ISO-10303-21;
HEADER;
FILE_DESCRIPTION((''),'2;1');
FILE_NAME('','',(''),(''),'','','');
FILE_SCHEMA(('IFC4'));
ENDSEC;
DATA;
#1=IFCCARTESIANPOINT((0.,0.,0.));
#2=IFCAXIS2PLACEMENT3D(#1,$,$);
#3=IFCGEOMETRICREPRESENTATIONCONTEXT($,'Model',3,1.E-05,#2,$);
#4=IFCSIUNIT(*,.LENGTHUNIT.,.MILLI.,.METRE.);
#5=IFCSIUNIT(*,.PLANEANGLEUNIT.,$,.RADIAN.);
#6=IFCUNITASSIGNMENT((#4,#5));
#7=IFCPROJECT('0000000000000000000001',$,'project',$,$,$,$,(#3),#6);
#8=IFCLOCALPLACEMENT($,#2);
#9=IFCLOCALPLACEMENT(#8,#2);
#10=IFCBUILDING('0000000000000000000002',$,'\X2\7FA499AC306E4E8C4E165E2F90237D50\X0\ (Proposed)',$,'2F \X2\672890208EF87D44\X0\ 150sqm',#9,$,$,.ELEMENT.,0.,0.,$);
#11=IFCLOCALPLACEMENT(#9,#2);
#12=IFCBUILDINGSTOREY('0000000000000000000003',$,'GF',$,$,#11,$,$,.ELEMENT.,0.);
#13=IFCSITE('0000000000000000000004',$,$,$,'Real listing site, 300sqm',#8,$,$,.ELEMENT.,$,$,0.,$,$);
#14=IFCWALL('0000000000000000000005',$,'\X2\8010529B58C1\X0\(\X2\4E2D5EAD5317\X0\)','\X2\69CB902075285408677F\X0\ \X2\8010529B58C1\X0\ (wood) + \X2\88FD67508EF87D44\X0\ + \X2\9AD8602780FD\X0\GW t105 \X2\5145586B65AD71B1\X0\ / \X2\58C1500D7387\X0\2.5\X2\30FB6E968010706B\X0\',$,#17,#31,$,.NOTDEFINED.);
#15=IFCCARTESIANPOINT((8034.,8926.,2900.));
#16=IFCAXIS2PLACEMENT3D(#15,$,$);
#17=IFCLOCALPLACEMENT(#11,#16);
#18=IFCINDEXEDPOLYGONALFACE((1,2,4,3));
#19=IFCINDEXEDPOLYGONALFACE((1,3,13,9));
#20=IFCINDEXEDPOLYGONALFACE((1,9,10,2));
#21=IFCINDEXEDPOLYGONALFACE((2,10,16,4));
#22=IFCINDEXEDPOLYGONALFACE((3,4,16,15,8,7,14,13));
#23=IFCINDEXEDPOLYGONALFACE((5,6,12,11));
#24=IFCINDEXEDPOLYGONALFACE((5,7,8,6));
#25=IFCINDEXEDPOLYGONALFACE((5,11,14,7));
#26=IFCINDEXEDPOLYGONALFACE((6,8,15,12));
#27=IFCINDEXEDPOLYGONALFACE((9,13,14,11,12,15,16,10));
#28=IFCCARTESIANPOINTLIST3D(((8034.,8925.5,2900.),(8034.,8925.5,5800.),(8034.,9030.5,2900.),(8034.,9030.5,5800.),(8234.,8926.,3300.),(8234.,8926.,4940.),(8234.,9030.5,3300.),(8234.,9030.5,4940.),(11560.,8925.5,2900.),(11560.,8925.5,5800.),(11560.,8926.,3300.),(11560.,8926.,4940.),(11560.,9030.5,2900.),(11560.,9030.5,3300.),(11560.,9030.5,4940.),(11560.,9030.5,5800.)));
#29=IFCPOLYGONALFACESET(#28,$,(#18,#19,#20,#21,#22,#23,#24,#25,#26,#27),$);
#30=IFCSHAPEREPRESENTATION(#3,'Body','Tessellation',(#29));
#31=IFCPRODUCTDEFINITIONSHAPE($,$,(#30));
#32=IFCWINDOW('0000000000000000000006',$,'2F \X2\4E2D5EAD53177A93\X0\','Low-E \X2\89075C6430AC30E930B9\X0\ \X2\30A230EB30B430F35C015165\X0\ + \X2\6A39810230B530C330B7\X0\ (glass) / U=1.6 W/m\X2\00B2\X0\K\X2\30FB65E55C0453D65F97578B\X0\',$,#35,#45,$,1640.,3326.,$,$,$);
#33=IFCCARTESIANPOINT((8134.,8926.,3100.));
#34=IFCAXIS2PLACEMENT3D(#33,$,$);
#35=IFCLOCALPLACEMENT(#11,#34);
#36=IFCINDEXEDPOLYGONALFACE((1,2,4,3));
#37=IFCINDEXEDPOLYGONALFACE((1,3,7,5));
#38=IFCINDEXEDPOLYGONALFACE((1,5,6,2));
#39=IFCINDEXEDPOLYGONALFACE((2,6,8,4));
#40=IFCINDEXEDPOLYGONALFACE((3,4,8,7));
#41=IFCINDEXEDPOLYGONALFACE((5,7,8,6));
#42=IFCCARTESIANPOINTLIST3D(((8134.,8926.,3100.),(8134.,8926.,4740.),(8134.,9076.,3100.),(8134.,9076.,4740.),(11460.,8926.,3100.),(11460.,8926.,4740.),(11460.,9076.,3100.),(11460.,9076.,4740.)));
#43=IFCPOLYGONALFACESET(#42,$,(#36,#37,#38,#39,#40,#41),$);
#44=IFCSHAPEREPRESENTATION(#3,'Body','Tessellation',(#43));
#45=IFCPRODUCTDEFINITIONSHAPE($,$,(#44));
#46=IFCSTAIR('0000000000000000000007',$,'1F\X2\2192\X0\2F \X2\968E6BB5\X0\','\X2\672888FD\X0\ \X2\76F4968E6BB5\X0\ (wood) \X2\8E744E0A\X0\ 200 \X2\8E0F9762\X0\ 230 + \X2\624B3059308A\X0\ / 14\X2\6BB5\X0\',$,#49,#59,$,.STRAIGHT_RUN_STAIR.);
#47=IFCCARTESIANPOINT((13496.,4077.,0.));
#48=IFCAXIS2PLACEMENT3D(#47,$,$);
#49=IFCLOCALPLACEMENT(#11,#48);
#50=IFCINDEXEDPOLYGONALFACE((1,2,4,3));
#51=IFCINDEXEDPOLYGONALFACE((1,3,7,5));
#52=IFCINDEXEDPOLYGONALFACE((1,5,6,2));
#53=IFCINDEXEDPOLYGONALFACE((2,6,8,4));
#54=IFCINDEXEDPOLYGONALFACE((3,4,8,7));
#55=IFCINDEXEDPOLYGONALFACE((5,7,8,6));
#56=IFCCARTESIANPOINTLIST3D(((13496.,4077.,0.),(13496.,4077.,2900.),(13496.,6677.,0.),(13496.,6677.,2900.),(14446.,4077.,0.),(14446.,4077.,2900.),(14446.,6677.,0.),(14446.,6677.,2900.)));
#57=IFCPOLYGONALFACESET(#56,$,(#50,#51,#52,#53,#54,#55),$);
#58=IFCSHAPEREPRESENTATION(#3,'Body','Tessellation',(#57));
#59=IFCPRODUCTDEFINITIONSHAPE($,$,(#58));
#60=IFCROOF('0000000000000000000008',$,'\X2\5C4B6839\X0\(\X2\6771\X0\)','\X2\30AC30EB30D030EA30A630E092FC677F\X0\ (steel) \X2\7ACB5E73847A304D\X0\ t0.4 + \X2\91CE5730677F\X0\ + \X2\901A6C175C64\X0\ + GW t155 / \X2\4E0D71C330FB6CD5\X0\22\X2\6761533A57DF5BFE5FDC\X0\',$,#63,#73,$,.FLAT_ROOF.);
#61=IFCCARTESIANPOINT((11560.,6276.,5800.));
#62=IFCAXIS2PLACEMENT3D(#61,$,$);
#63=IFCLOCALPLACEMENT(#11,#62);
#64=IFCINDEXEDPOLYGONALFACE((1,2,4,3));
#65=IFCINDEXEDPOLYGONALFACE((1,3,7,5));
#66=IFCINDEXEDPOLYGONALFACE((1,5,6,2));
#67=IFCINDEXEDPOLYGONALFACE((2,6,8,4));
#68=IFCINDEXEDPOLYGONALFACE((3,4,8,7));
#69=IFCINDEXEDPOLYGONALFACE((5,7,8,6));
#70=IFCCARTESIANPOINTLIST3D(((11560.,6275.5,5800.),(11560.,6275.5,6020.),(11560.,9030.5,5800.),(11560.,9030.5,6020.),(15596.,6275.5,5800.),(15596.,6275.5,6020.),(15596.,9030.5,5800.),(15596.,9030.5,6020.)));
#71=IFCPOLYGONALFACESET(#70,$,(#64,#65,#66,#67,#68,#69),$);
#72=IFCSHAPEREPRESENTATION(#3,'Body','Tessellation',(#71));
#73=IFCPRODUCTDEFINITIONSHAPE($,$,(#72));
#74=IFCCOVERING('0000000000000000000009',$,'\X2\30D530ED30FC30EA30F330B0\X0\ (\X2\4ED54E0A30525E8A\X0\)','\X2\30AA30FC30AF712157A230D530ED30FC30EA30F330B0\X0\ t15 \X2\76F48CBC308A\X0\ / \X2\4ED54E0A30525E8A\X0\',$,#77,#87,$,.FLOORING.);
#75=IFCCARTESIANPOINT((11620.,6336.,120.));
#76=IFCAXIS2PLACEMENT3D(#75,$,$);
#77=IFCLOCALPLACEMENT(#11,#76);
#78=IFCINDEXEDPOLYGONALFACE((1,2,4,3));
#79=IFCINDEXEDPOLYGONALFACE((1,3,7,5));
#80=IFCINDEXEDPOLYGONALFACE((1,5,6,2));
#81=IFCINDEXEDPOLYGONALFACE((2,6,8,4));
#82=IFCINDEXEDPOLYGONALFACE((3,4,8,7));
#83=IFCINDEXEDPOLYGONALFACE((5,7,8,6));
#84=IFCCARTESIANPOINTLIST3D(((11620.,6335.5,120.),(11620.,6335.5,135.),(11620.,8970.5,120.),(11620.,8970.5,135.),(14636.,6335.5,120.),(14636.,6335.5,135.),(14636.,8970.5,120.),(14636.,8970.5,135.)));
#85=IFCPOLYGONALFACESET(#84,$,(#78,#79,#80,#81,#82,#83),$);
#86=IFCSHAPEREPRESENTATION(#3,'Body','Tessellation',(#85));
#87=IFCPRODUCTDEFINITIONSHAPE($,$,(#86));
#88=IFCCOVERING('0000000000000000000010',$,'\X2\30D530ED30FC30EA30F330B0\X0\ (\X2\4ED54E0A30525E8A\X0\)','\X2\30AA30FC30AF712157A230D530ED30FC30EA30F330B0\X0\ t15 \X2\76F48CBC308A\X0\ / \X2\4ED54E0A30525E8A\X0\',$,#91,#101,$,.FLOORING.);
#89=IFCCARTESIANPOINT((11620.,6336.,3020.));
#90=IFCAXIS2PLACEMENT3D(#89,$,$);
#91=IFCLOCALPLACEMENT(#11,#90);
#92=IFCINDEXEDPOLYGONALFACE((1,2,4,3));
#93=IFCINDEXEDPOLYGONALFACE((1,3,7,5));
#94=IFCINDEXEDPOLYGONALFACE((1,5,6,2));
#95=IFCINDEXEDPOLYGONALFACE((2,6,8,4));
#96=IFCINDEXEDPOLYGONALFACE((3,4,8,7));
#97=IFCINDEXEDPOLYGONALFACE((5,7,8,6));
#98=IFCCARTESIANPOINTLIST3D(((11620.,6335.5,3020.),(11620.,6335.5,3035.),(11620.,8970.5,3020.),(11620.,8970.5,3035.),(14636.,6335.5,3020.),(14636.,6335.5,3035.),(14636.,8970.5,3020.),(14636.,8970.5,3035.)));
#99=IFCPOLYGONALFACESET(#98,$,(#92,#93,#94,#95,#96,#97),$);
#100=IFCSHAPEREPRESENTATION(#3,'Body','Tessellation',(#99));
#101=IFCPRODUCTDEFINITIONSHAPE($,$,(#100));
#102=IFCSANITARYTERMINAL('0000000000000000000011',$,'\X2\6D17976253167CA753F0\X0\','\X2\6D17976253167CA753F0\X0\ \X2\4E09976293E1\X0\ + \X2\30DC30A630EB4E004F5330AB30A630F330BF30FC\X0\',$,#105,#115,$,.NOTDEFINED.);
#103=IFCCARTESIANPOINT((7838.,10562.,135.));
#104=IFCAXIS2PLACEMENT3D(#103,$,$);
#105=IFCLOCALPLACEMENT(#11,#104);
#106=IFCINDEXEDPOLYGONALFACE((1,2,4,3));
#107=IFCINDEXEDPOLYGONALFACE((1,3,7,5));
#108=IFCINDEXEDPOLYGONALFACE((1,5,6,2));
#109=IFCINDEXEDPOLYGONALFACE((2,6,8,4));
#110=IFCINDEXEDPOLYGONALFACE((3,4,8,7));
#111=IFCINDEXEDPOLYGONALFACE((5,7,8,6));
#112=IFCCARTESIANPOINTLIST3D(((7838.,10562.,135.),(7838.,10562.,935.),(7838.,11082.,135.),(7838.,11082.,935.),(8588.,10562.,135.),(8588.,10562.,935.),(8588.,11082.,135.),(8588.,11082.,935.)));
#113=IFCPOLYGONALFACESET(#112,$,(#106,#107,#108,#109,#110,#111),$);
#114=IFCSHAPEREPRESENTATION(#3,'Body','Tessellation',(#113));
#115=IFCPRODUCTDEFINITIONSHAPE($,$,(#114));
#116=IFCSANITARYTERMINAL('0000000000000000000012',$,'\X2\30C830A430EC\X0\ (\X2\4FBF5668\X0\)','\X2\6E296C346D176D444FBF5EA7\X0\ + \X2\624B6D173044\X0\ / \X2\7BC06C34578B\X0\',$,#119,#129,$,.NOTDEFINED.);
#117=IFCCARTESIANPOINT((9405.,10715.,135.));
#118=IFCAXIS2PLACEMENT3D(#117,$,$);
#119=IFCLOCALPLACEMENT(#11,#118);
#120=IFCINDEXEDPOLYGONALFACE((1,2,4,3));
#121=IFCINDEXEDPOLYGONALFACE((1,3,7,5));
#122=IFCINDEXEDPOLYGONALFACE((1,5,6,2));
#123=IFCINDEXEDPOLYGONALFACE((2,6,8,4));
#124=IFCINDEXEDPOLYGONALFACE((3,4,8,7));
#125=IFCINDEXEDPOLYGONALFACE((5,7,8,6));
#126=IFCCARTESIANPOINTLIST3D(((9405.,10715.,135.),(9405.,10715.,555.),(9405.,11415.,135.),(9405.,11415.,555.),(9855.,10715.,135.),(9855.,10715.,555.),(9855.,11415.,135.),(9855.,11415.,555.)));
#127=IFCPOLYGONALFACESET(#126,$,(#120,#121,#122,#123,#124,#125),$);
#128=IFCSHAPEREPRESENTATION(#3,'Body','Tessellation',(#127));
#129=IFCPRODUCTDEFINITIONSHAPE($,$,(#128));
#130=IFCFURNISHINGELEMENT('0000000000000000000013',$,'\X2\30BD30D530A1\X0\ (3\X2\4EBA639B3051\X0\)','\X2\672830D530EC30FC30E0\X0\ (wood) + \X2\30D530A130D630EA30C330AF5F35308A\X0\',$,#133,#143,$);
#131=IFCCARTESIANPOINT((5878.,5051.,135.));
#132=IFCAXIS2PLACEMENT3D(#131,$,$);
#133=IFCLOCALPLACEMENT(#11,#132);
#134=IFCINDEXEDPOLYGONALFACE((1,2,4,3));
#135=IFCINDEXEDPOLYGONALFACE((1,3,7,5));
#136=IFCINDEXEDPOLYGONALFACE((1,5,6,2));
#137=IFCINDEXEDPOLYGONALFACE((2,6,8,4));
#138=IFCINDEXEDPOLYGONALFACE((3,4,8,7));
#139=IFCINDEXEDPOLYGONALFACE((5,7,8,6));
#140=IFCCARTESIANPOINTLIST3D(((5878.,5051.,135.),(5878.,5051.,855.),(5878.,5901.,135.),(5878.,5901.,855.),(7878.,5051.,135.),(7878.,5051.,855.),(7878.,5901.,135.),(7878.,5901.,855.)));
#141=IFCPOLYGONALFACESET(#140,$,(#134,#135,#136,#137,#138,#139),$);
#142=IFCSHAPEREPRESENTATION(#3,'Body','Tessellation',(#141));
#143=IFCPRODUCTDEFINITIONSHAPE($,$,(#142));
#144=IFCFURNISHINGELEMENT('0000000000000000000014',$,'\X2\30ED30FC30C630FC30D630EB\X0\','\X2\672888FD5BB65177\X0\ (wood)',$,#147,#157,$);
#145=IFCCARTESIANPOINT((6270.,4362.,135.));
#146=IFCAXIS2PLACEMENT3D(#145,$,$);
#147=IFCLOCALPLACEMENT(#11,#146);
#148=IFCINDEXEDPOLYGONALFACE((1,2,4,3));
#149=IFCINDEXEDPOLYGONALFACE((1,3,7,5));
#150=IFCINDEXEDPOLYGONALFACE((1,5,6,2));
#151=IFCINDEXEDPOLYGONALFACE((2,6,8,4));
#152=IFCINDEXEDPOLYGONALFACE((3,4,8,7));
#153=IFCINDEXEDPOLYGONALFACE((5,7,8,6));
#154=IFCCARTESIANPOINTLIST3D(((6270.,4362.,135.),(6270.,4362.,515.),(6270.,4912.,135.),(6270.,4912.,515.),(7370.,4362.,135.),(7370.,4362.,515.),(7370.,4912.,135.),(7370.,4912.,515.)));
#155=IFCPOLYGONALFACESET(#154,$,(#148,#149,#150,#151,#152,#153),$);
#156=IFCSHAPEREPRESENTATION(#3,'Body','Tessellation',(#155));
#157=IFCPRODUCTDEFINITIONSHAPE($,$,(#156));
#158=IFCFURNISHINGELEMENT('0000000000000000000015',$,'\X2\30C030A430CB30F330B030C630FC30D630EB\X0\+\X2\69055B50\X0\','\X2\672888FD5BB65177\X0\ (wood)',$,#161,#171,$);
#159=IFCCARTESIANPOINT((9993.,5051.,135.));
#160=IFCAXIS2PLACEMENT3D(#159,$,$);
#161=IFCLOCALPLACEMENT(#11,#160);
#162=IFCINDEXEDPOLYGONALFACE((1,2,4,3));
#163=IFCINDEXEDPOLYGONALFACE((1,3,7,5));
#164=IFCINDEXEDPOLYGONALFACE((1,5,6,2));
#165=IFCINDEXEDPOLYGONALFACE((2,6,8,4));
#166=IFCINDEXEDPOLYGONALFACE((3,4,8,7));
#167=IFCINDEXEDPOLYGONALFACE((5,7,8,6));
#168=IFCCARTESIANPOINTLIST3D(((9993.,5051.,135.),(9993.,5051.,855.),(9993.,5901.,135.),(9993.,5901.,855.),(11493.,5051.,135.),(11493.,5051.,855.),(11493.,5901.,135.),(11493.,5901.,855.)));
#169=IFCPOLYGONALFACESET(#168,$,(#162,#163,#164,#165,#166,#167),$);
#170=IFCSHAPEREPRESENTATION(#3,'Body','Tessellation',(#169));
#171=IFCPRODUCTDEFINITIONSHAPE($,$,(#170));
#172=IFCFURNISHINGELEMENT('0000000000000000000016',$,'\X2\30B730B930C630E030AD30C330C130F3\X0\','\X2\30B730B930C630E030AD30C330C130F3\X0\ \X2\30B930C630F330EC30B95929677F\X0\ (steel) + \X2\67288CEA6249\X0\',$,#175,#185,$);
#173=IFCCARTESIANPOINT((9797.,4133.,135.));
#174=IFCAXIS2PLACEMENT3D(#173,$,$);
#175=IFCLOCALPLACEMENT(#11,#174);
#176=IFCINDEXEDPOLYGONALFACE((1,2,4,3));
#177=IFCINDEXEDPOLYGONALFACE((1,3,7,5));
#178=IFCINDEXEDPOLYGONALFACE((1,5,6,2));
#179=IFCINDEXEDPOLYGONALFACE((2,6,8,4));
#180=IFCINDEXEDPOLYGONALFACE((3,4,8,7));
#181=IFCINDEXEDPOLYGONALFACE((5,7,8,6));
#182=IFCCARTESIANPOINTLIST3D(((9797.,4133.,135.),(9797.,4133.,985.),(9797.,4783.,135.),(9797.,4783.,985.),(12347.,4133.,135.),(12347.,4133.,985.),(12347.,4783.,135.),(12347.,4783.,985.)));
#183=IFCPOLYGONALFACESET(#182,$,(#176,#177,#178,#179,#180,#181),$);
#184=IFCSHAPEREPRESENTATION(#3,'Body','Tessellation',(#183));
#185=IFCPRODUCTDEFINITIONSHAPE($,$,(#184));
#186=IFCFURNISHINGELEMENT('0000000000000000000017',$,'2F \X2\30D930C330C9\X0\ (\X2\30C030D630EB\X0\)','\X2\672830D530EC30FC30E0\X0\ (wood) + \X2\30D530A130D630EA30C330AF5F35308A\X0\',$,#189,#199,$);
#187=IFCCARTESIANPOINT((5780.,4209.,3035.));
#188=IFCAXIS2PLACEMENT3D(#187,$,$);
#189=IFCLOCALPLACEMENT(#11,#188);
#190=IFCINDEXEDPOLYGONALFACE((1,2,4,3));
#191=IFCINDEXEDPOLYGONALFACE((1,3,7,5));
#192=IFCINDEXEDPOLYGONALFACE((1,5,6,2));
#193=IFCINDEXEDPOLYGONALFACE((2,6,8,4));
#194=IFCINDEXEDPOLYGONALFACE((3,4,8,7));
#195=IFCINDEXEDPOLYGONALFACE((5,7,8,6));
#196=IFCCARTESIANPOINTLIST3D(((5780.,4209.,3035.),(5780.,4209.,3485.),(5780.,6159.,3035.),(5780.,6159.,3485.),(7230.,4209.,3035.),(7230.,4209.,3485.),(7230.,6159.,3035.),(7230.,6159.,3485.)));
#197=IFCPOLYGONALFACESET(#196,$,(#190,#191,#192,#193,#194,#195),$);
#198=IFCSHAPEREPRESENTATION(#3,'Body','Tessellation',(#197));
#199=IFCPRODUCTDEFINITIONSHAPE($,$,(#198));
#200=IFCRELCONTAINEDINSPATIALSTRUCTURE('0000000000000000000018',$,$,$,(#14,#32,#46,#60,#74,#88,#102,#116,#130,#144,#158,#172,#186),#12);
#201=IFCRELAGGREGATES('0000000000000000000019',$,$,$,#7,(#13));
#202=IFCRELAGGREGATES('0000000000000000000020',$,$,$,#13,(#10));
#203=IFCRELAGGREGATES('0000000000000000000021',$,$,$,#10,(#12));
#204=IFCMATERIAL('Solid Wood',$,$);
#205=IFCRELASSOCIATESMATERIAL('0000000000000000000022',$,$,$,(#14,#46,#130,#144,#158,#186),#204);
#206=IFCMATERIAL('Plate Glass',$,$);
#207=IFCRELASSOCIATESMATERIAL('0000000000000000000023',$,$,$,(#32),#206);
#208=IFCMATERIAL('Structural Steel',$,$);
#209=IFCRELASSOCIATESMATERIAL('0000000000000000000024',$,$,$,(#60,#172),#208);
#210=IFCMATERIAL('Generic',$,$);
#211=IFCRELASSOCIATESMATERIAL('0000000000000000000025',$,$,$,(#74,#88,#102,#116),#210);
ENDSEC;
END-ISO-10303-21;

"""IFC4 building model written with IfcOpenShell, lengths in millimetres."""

from ifc_helpers import new_model, si_unit, frame, frame_2d, origin, place, context, project, spatial, rectangle, extrude, material, element, fill, save


model = new_model("IFC4")

# Units and contexts
model_context = context("Model", 3, precision=1e-05, world=origin())
ifc_project = project(units=[si_unit("LENGTHUNIT", "METRE", prefix="MILLI"), si_unit("PLANEANGLEUNIT", "RADIAN")], contexts=[model_context])

# Site, building, storey
site_placement = place(None, origin())
site = spatial("IfcSite", under=ifc_project, at=site_placement, ObjectType="Real listing site, 300sqm", CompositionType="ELEMENT", RefElevation=0.0)
building_placement = place(site_placement, origin())
building = spatial("IfcBuilding", under=site, at=building_placement, Name="群馬の二世帯連結 (Proposed)", ObjectType="2F 木造軸組 150sqm", CompositionType="ELEMENT", ElevationOfRefHeight=0.0, ElevationOfTerrain=0.0)
storey_placement = place(building_placement, origin())
storey = spatial("IfcBuildingStorey", under=building, at=storey_placement, Name="GF", CompositionType="ELEMENT", Elevation=0.0)

# Shared definitions
ifc_material_1 = material(Name="Solid Wood")

# Shared definitions
ifc_material_2 = material(Name="Plate Glass")

# Wall, opening, window
wall_1_placement = place(storey_placement, frame((8034.0, 8926.0, 2900.0)))
wall_1 = element("IfcWall", 1, at=wall_1_placement, inside=storey, material=ifc_material_1, Name="耐力壁(中庭北)", Description="構造用合板 耐力壁 (wood) + 製材軸組 + 高性能GW t105 充填断熱 / 壁倍率2.5・準耐火", PredefinedType="NOTDEFINED", context=model_context, shape_type="SweptSolid", body=[
    extrude(rectangle(XDim=3526.0, YDim=105.0, at=frame_2d((1763.0, 52.0))), frame((8034.0, 8926.0, 2900.0)), (0.0, 0.0, 1.0), 2900.0),
])
opening_1_placement = place(storey_placement, frame((8134.0, 8926.0, 3100.0)))
opening_1 = element("IfcOpeningElement", 2, at=opening_1_placement, cuts=wall_1, PredefinedType="NOTDEFINED", context=model_context, shape_type="SweptSolid", body=[
    extrude(rectangle(XDim=3326.0, YDim=150.0, at=frame_2d((1663.0, 75.0))), frame((8134.0, 8926.0, 3100.0)), (0.0, 0.0, 1.0), 1640.0),
])
window_1_placement = place(storey_placement, frame((8134.0, 8926.0, 3100.0)))
window_1 = element("IfcWindow", 3, at=window_1_placement, inside=storey, material=ifc_material_2, Name="2F 中庭北窓", Description="Low-E 複層ガラス アルゴン封入 + 樹脂サッシ (glass) / U=1.6 W/m²K・日射取得型", OverallHeight=1640.0, OverallWidth=3326.0, context=model_context, shape_type="SweptSolid", body=[
    extrude(rectangle(XDim=3326.0, YDim=150.0, at=frame_2d((1663.0, 75.0))), frame((8134.0, 8926.0, 3100.0)), (0.0, 0.0, 1.0), 1640.0),
])
fill(opening_1, window_1)

# Stair
stair_placement = place(storey_placement, frame((13496.0, 4077.0, 0.0)))
element("IfcStair", 4, at=stair_placement, inside=storey, material=ifc_material_1, Name="1F→2F 階段", Description="木製 直階段 (wood) 蹴上 200 踏面 230 + 手すり / 14段", PredefinedType="STRAIGHT_RUN_STAIR", context=model_context, shape_type="SweptSolid", body=[
    extrude(rectangle(XDim=950.0, YDim=2600.0, at=frame_2d((475.0, 1300.0))), frame((13496.0, 4077.0, 0.0)), (0.0, 0.0, 1.0), 2900.0),
])

# Roof
ifc_material_3 = material(Name="Structural Steel")
for number, where, name in (
    (5, (11560.0, 6276.0, 5800.0), "屋根(東)"),
):
    element("IfcRoof", number, at=place(storey_placement, frame(where)), inside=storey, material=ifc_material_3, Name=name, Description="ガルバリウム鋼板 (steel) 立平葺き t0.4 + 野地板 + 通気層 + GW t155 / 不燃・法22条区域対応", PredefinedType="FLAT_ROOF", context=model_context, shape_type="SweptSolid", body=[
        extrude(rectangle(XDim=4036.0, YDim=2755.0, at=frame_2d((2018.0, 1377.0))), frame((11560.0, 6276.0, 5800.0)), (0.0, 0.0, 1.0), 220.0),
    ])

# Coverings
ifc_material_4 = material(Name="Generic")
covering_1_placement = place(storey_placement, frame((11620.0, 6336.0, 120.0)))
element("IfcCovering", 6, at=covering_1_placement, inside=storey, material=ifc_material_4, Name="フローリング (仕上げ床)", Description="オーク無垢フローリング t15 直貼り / 仕上げ床", PredefinedType="FLOORING", context=model_context, shape_type="SweptSolid", body=[
    extrude(rectangle(XDim=3016.0, YDim=2635.0, at=frame_2d((1508.0, 1317.0))), frame((11620.0, 6336.0, 120.0)), (0.0, 0.0, 1.0), 15.0),
])
covering_2_placement = place(storey_placement, frame((11620.0, 6336.0, 3020.0)))
element("IfcCovering", 7, at=covering_2_placement, inside=storey, material=ifc_material_4, Name="フローリング (仕上げ床)", Description="オーク無垢フローリング t15 直貼り / 仕上げ床", PredefinedType="FLOORING", context=model_context, shape_type="SweptSolid", body=[
    extrude(rectangle(XDim=3016.0, YDim=2635.0, at=frame_2d((1508.0, 1317.0))), frame((11620.0, 6336.0, 3020.0)), (0.0, 0.0, 1.0), 15.0),
])

# Sanitary terminals
sanitary_terminal_1_placement = place(storey_placement, frame((7838.0, 10562.0, 135.0)))
element("IfcSanitaryTerminal", 8, at=sanitary_terminal_1_placement, inside=storey, material=ifc_material_4, Name="洗面化粧台", Description="洗面化粧台 三面鏡 + ボウル一体カウンター", PredefinedType="NOTDEFINED", context=model_context, shape_type="SweptSolid", body=[
    extrude(rectangle(XDim=750.0, YDim=520.0, at=frame_2d((375.0, 260.0))), frame((7838.0, 10562.0, 135.0)), (0.0, 0.0, 1.0), 800.0),
])
sanitary_terminal_2_placement = place(storey_placement, frame((9405.0, 10715.0, 135.0)))
element("IfcSanitaryTerminal", 9, at=sanitary_terminal_2_placement, inside=storey, material=ifc_material_4, Name="トイレ (便器)", Description="温水洗浄便座 + 手洗い / 節水型", PredefinedType="NOTDEFINED", context=model_context, shape_type="SweptSolid", body=[
    extrude(rectangle(XDim=450.0, YDim=700.0, at=frame_2d((225.0, 350.0))), frame((9405.0, 10715.0, 135.0)), (0.0, 0.0, 1.0), 420.0),
])

# Furnishing elements
furnishing_1_placement = place(storey_placement, frame((5878.0, 5051.0, 135.0)))
element("IfcFurnishingElement", 10, at=furnishing_1_placement, inside=storey, material=ifc_material_1, Name="ソファ (3人掛け)", Description="木フレーム (wood) + ファブリック張り", context=model_context, shape_type="SweptSolid", body=[
    extrude(rectangle(XDim=2000.0, YDim=850.0, at=frame_2d((1000.0, 425.0))), frame((5878.0, 5051.0, 135.0)), (0.0, 0.0, 1.0), 720.0),
])
furnishing_2_placement = place(storey_placement, frame((6270.0, 4362.0, 135.0)))
element("IfcFurnishingElement", 11, at=furnishing_2_placement, inside=storey, material=ifc_material_1, Name="ローテーブル", Description="木製家具 (wood)", context=model_context, shape_type="SweptSolid", body=[
    extrude(rectangle(XDim=1100.0, YDim=550.0, at=frame_2d((550.0, 275.0))), frame((6270.0, 4362.0, 135.0)), (0.0, 0.0, 1.0), 380.0),
])
furnishing_3_placement = place(storey_placement, frame((9993.0, 5051.0, 135.0)))
element("IfcFurnishingElement", 12, at=furnishing_3_placement, inside=storey, material=ifc_material_1, Name="ダイニングテーブル+椅子", Description="木製家具 (wood)", context=model_context, shape_type="SweptSolid", body=[
    extrude(rectangle(XDim=1500.0, YDim=850.0, at=frame_2d((750.0, 425.0))), frame((9993.0, 5051.0, 135.0)), (0.0, 0.0, 1.0), 720.0),
])
furnishing_4_placement = place(storey_placement, frame((9797.0, 4133.0, 135.0)))
element("IfcFurnishingElement", 13, at=furnishing_4_placement, inside=storey, material=ifc_material_3, Name="システムキッチン", Description="システムキッチン ステンレス天板 (steel) + 木質扉", context=model_context, shape_type="SweptSolid", body=[
    extrude(rectangle(XDim=2550.0, YDim=650.0, at=frame_2d((1275.0, 325.0))), frame((9797.0, 4133.0, 135.0)), (0.0, 0.0, 1.0), 850.0),
])
furnishing_5_placement = place(storey_placement, frame((5780.0, 4209.0, 3035.0)))
element("IfcFurnishingElement", 14, at=furnishing_5_placement, inside=storey, material=ifc_material_1, Name="2F ベッド (ダブル)", Description="木フレーム (wood) + ファブリック張り", context=model_context, shape_type="SweptSolid", body=[
    extrude(rectangle(XDim=1450.0, YDim=1950.0, at=frame_2d((725.0, 975.0))), frame((5780.0, 4209.0, 3035.0)), (0.0, 0.0, 1.0), 450.0),
])

save(model, "model.ifc")
